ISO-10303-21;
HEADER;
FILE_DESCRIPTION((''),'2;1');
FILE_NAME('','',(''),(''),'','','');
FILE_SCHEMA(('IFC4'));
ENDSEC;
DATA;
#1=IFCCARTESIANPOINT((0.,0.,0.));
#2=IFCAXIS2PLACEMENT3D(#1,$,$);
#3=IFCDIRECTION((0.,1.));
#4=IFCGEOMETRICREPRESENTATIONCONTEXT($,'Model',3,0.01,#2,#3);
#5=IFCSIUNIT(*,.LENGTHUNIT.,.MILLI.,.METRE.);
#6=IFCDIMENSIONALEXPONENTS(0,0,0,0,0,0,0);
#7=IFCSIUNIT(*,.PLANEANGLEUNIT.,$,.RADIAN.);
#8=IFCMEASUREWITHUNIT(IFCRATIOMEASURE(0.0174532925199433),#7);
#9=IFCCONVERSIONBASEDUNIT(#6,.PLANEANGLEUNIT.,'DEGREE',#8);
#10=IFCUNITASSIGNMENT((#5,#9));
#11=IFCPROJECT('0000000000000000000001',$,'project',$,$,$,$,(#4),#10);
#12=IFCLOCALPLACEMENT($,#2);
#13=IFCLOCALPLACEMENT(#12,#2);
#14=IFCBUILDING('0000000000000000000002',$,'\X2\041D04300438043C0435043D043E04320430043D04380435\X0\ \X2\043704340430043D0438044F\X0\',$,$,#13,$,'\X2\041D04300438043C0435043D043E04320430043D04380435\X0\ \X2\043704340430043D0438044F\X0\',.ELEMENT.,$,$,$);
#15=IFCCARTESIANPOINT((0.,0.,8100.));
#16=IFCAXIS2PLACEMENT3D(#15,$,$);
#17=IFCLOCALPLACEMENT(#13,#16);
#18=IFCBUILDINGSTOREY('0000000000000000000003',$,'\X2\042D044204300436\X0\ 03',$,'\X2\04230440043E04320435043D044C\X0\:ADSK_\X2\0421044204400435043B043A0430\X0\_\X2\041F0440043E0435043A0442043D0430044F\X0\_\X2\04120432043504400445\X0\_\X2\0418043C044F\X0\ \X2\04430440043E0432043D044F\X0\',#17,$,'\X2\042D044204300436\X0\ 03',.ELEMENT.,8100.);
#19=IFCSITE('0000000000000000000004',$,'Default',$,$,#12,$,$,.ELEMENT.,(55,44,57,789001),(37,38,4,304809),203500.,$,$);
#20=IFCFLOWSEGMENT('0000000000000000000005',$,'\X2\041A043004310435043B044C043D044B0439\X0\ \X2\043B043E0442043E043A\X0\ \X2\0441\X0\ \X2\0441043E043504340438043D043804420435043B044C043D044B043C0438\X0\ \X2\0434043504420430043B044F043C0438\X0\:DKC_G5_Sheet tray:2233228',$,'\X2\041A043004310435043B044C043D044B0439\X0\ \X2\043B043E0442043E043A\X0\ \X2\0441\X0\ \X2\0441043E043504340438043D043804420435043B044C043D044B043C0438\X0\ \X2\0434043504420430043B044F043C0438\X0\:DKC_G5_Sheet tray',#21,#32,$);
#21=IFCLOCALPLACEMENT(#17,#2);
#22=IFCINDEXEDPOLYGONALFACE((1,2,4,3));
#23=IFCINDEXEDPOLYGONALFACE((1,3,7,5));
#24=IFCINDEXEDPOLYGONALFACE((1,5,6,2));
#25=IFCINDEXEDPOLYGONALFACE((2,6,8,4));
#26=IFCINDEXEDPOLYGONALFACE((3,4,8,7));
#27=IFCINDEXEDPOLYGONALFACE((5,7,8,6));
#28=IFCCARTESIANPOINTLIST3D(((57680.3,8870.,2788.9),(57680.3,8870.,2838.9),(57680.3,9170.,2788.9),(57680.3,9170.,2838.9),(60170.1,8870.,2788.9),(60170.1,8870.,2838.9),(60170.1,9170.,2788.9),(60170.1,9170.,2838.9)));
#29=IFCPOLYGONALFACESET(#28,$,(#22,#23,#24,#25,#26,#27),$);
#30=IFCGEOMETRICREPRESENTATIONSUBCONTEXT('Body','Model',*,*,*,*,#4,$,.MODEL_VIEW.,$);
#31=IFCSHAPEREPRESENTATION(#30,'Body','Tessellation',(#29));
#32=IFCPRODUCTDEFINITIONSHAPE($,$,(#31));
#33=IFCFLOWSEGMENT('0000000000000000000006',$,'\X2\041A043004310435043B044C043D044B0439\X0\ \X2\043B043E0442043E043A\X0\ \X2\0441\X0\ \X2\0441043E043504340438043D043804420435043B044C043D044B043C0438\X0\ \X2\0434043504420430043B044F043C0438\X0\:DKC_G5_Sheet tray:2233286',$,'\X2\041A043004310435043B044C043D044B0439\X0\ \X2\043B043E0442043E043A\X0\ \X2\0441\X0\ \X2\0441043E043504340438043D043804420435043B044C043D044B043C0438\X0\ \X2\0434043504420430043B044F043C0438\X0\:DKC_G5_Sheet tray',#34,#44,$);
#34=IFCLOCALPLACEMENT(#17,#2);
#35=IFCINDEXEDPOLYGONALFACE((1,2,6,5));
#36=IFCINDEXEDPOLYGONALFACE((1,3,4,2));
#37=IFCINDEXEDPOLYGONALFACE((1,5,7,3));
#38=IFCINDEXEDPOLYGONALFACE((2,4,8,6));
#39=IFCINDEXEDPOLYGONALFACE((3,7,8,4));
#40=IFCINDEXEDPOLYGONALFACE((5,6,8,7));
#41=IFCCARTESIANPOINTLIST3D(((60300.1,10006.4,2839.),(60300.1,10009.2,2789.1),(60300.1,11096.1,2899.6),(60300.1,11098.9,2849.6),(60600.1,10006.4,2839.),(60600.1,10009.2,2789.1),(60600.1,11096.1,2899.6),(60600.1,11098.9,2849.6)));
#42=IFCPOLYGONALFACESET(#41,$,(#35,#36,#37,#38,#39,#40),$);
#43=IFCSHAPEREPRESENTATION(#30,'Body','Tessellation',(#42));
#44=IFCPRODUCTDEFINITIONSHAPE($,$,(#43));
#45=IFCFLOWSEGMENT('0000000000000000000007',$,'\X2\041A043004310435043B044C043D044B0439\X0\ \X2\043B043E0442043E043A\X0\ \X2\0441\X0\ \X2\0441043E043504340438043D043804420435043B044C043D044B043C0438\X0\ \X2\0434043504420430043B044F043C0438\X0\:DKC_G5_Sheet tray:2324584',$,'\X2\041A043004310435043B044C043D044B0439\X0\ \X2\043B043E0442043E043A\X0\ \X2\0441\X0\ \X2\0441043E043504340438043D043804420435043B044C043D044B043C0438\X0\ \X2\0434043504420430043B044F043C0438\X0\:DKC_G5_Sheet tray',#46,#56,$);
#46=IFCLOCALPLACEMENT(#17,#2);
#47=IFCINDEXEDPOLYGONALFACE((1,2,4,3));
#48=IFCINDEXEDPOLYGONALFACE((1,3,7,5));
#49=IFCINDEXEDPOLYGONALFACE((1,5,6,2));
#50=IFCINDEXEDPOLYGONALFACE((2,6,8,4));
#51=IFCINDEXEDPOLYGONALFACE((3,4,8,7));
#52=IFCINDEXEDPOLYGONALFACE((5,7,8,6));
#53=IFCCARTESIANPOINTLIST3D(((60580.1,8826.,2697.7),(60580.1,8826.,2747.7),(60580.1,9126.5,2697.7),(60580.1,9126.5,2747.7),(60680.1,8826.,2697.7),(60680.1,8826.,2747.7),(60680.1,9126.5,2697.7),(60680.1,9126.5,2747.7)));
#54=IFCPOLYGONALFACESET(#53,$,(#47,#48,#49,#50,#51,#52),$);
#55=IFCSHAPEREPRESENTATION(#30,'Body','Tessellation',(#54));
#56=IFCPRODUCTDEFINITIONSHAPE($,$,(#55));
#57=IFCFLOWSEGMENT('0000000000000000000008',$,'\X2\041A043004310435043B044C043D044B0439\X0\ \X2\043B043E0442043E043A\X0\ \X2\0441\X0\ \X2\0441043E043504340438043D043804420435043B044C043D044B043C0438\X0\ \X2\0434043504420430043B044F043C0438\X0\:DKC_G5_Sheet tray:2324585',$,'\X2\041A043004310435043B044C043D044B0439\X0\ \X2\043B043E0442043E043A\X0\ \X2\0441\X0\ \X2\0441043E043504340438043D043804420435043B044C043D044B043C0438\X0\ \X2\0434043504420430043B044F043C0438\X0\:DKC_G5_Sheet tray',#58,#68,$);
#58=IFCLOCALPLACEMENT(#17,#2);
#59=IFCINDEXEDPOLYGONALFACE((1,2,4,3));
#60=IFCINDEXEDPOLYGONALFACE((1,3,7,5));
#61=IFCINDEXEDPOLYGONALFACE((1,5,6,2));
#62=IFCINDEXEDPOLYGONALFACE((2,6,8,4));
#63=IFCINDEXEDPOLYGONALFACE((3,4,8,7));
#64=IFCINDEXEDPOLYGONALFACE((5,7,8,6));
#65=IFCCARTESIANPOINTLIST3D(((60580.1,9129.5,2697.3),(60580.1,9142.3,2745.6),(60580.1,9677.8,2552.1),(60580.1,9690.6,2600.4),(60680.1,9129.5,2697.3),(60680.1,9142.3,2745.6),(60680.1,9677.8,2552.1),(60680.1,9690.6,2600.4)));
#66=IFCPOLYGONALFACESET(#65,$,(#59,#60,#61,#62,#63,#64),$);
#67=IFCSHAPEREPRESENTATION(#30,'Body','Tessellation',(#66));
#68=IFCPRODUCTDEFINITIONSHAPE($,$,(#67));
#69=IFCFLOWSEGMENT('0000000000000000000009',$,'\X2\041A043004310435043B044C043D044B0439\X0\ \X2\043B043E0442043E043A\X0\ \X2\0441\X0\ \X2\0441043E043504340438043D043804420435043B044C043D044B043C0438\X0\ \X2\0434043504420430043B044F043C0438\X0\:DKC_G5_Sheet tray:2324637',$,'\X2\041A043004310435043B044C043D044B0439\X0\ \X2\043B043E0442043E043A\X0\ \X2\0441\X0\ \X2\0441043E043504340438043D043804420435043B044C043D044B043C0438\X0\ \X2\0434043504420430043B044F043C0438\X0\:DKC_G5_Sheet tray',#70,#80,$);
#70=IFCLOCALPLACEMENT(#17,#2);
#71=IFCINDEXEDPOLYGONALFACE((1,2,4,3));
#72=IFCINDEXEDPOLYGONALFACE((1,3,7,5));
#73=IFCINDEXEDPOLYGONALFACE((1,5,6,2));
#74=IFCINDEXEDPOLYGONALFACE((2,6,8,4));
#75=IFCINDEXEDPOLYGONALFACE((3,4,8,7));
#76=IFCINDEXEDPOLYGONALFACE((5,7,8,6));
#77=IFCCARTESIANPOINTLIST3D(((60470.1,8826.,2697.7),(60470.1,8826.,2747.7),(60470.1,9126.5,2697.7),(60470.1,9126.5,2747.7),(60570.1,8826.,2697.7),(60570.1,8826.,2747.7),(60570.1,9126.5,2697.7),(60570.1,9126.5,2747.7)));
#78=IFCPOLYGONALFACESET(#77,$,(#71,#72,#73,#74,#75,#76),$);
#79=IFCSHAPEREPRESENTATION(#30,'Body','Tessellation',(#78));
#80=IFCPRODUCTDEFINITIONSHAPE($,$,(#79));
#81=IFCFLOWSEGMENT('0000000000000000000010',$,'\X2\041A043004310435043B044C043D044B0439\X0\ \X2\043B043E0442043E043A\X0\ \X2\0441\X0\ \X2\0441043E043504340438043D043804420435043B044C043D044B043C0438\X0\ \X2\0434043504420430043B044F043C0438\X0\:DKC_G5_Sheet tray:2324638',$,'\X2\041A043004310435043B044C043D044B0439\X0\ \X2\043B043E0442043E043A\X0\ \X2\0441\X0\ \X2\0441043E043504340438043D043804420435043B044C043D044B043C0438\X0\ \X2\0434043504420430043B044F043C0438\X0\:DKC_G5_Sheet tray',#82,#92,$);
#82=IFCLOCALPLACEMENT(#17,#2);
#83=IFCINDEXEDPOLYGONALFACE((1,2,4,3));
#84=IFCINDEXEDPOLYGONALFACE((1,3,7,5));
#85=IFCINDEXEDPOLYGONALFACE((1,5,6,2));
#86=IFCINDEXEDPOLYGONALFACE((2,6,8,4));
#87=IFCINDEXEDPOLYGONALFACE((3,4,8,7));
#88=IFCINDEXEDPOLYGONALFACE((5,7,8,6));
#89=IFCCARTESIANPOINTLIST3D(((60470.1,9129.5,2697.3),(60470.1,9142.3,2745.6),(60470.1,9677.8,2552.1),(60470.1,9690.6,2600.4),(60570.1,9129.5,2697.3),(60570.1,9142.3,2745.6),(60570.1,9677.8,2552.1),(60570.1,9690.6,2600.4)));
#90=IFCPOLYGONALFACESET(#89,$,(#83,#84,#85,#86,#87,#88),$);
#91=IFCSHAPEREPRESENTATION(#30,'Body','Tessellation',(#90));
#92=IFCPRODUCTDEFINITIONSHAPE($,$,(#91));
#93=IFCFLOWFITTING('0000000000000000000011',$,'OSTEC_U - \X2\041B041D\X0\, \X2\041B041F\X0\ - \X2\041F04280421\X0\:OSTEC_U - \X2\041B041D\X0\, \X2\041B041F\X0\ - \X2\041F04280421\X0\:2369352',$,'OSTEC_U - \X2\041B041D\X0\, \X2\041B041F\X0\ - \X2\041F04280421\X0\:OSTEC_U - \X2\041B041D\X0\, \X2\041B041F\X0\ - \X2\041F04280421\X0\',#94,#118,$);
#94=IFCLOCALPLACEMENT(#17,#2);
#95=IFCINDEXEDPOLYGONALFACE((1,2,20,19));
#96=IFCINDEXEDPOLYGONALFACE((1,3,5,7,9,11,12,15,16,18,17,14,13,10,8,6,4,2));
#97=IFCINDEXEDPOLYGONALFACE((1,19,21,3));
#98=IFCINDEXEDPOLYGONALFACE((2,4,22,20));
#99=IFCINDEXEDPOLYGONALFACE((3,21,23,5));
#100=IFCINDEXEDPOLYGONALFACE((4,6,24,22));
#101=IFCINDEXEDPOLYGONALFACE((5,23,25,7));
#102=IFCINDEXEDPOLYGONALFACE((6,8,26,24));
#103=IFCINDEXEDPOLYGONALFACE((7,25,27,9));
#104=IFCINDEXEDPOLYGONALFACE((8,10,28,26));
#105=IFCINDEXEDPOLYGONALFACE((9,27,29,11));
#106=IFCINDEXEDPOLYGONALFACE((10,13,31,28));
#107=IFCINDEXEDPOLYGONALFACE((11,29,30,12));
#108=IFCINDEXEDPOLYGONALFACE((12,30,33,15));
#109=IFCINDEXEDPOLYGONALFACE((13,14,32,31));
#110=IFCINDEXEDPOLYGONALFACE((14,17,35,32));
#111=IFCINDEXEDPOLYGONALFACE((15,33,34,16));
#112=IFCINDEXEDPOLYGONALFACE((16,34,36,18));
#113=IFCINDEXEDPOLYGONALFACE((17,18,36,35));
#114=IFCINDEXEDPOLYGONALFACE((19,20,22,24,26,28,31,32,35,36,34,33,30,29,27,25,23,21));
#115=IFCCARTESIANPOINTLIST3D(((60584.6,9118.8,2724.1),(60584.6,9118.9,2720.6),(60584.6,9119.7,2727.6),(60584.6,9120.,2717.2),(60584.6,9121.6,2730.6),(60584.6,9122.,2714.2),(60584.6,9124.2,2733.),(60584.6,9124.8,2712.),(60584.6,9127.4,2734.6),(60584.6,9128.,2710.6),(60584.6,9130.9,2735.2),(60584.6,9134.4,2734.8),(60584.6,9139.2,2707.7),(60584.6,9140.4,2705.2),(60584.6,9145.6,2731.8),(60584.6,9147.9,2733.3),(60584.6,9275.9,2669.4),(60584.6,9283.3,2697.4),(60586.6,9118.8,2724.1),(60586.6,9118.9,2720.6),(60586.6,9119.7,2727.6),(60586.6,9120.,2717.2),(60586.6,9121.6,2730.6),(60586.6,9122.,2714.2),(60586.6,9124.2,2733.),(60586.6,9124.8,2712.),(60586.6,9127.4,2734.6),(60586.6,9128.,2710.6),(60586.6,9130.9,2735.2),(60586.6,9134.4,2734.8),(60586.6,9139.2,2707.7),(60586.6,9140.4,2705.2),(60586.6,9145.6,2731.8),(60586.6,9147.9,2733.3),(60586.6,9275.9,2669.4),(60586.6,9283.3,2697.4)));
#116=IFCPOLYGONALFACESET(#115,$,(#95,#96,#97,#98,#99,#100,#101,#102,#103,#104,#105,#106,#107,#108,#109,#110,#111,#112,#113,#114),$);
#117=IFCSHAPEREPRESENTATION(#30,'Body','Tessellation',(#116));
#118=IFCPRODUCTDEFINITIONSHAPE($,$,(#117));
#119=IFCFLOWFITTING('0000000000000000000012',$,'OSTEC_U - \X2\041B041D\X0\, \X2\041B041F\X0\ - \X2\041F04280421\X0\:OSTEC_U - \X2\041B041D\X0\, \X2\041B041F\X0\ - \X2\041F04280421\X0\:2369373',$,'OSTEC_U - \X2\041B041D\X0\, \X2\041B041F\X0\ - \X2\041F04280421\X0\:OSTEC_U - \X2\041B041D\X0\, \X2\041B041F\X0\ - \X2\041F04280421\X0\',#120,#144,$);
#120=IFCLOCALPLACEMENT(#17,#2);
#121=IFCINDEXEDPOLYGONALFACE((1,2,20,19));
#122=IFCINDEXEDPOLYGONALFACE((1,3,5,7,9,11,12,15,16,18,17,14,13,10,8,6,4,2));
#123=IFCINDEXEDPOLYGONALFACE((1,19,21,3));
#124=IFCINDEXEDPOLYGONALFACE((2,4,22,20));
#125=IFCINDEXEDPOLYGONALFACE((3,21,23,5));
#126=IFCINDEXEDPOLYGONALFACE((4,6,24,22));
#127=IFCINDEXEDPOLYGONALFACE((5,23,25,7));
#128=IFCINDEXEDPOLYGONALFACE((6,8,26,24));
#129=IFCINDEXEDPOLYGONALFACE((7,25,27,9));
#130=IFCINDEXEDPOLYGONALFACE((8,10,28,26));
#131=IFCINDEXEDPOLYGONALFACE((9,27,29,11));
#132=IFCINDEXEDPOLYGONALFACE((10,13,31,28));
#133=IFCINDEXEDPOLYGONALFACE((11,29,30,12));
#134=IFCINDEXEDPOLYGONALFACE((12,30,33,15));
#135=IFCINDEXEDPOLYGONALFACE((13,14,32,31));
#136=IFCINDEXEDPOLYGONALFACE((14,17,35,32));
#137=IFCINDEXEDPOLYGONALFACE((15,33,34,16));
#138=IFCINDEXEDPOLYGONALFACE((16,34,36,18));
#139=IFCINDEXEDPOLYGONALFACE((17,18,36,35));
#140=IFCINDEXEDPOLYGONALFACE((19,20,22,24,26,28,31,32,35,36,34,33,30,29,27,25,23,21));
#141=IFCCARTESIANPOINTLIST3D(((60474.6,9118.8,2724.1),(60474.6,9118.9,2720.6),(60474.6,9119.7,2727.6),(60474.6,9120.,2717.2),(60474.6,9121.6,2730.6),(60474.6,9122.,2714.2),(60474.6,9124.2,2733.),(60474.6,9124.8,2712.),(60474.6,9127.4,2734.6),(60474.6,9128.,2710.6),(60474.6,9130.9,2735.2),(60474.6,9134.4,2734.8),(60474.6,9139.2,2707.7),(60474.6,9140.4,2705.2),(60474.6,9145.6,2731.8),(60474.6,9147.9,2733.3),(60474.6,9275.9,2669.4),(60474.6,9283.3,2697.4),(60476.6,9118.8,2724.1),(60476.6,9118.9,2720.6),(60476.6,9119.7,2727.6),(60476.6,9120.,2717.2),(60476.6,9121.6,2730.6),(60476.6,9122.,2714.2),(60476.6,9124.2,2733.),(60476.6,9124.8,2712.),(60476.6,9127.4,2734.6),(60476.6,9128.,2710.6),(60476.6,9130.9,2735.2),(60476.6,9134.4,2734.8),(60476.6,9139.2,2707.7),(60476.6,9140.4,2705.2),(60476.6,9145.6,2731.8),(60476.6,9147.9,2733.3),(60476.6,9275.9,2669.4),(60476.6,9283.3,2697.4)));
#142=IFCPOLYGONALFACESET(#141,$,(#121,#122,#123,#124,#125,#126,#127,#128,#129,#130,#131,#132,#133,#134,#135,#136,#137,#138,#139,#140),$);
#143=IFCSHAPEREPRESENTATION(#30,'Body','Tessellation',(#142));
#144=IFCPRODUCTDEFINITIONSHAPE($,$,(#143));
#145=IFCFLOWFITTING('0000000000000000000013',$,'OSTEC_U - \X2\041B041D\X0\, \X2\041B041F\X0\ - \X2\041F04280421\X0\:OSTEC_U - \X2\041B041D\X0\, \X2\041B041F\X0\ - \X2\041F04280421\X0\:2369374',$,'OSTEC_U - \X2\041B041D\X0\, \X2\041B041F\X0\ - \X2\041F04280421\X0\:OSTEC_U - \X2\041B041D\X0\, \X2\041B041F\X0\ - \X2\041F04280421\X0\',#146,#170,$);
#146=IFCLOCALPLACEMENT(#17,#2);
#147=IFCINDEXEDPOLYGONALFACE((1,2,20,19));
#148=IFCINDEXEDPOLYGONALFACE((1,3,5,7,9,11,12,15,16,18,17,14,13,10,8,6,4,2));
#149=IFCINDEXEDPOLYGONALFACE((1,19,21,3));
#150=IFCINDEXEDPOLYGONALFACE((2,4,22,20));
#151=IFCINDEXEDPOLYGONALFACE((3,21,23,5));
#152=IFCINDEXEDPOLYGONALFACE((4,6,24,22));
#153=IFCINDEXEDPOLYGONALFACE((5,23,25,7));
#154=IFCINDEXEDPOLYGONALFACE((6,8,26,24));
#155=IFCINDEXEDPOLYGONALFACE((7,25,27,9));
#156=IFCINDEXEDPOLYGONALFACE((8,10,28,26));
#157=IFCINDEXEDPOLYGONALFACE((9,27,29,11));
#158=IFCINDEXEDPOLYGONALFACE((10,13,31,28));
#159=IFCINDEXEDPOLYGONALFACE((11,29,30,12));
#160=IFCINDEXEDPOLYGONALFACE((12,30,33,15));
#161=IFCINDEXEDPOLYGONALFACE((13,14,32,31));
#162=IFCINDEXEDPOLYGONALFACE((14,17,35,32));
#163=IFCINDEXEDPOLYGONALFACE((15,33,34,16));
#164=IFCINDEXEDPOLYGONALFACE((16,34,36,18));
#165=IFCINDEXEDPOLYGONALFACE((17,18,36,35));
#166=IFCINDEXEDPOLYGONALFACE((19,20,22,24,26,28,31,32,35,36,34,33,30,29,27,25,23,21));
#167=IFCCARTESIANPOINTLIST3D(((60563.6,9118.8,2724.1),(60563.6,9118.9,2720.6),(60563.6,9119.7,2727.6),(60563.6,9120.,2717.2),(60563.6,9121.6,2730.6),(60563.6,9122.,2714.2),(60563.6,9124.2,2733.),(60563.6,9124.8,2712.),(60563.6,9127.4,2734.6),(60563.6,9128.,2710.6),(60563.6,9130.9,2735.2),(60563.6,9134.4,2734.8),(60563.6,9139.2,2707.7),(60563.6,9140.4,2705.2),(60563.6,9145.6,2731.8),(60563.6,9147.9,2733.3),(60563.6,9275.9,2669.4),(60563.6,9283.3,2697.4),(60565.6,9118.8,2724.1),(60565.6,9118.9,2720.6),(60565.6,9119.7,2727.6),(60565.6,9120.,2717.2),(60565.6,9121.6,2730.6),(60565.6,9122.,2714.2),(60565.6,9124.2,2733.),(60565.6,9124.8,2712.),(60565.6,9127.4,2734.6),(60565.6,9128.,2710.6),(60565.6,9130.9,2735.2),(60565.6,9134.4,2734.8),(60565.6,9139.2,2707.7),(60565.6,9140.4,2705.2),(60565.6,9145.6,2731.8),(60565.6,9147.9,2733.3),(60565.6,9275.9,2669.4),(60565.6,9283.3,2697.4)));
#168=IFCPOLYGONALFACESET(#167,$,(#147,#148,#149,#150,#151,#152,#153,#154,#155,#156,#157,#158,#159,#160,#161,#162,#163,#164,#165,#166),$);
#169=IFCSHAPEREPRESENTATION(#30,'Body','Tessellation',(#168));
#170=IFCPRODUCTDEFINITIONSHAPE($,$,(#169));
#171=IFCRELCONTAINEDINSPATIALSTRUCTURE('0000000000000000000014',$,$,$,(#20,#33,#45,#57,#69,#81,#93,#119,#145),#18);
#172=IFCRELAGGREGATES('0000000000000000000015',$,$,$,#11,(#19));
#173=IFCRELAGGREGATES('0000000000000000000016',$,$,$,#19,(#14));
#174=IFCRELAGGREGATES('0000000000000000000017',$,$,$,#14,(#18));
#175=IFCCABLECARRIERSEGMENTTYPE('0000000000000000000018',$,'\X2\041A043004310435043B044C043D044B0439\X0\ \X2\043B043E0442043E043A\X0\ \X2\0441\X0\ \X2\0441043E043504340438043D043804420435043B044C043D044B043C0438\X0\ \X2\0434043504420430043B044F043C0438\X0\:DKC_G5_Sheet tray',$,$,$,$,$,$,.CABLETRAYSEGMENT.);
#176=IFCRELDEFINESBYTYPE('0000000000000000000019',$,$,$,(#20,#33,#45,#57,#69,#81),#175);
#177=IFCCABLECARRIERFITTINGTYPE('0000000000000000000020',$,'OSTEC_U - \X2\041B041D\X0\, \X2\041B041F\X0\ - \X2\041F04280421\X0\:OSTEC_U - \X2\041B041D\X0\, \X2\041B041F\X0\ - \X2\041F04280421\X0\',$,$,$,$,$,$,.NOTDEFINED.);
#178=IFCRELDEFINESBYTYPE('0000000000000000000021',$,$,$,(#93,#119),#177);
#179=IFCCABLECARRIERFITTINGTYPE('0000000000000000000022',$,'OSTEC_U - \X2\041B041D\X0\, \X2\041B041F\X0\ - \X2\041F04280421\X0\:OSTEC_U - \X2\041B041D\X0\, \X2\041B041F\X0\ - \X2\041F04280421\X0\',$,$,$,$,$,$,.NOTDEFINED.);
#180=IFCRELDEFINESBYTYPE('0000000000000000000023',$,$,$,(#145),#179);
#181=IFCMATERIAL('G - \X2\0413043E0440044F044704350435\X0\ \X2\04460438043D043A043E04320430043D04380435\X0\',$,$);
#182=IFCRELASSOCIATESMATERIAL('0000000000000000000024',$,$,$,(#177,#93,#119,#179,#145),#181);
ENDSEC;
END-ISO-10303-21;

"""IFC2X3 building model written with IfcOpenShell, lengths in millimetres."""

from ifc_helpers import new_model, entity, si_unit, converted_unit, direction, frame, frame_2d, origin, place, context, subcontext, project, spatial, polyline, circle_curve, parameter, trimmed, segment, composite_curve, rectangle, outline, extrude, source, transform, mapped, material, type_object, type_shapes, element, save


model = new_model("IFC2X3")

# Units and contexts
model_context = context("Model", 3, precision=0.01, world=origin(), true_north=direction((0.0, 1.0)))
body_context = subcontext(model_context, "Body", "Model", "MODEL_VIEW")
ifc_project = project(units=[si_unit("LENGTHUNIT", "METRE", prefix="MILLI"), converted_unit("PLANEANGLEUNIT", "DEGREE", entity("IfcRatioMeasure", 0.0174532925199433), si_unit("PLANEANGLEUNIT", "RADIAN"), dimensions=[0, 0, 0, 0, 0, 0, 0])], contexts=[model_context])

# Site, building, storey
site_placement = place(None, frame((0.0, 0.0, 0.0)))
site = spatial("IfcSite", under=ifc_project, at=site_placement, Name="Default", CompositionType="ELEMENT", RefLatitude=(55, 44, 57, 789001), RefLongitude=(37, 38, 4, 304809), RefElevation=203500.0)
building_placement = place(site_placement, origin())
building = spatial("IfcBuilding", under=site, at=building_placement, Name="Наименование здания", LongName="Наименование здания", CompositionType="ELEMENT")
storey_placement = place(building_placement, frame((0.0, 0.0, 8100.0)))
storey = spatial("IfcBuildingStorey", under=building, at=storey_placement, Name="Этаж 03", ObjectType="Уровень:ADSK_Стрелка_Проектная_Вверх_Имя уровня", LongName="Этаж 03", CompositionType="ELEMENT", Elevation=8100.0)

# Flow segments
cable_carrier_segment_type = type_object("IfcCableCarrierSegmentType", Name="Кабельный лоток с соединительными деталями:DKC_G5_Sheet tray", PredefinedType="CABLETRAYSEGMENT")
flow_segment_1_placement = place(storey_placement, frame((57680.3, 8870.0, 2788.9)))
element("IfcFlowSegment", 1, at=flow_segment_1_placement, inside=storey, type_object=cable_carrier_segment_type, Name="Кабельный лоток с соединительными деталями:DKC_G5_Sheet tray:2233228", ObjectType="Кабельный лоток с соединительными деталями:DKC_G5_Sheet tray", context=body_context, shape_type="SweptSolid", body=[
    extrude(rectangle(XDim=2489.9, YDim=300.0, at=frame_2d((0.0, 0.0), x_axis=(1.0, 0.0))), frame((1244.9, 150.0, 0.0)), (0.0, 0.0, 1.0), 50.0),
])
flow_segment_2_placement = place(storey_placement, frame((60300.1, 10006.4, 2789.1)))
element("IfcFlowSegment", 2, at=flow_segment_2_placement, inside=storey, type_object=cable_carrier_segment_type, Name="Кабельный лоток с соединительными деталями:DKC_G5_Sheet tray:2233286", ObjectType="Кабельный лоток с соединительными деталями:DKC_G5_Sheet tray", context=body_context, shape_type="SweptSolid", body=[
    extrude(rectangle(XDim=50.0, YDim=1091.4, at=frame_2d((0.0, 0.0), x_axis=(0.0, 1.0))), frame((0.0, 546.2, 55.3), z_axis=(1.0, 0.0, 0.0), x_axis=(0.0, -0.998458, -0.055513)), (0.0, 0.0, 1.0), 300.0),
])
flow_segment_3_placement = place(storey_placement, frame((60580.1, 8826.0, 2697.7)))
element("IfcFlowSegment", 3, at=flow_segment_3_placement, inside=storey, type_object=cable_carrier_segment_type, Name="Кабельный лоток с соединительными деталями:DKC_G5_Sheet tray:2324584", ObjectType="Кабельный лоток с соединительными деталями:DKC_G5_Sheet tray", context=body_context, shape_type="SweptSolid", body=[
    extrude(rectangle(XDim=300.4, YDim=100.0, at=frame_2d((0.0, 0.0), x_axis=(1.0, 0.0))), frame((50.0, 150.2, 0.0), z_axis=(0.0, 0.0, 1.0), x_axis=(0.0, -1.0, 0.0)), (0.0, 0.0, 1.0), 50.0),
])
flow_segment_4_placement = place(storey_placement, frame((60580.1, 9129.5, 2552.1)))
element("IfcFlowSegment", 4, at=flow_segment_4_placement, inside=storey, type_object=cable_carrier_segment_type, Name="Кабельный лоток с соединительными деталями:DKC_G5_Sheet tray:2324585", ObjectType="Кабельный лоток с соединительными деталями:DKC_G5_Sheet tray", context=body_context, shape_type="SweptSolid", body=[
    extrude(rectangle(XDim=50.0, YDim=567.3, at=frame_2d((0.0, 0.0), x_axis=(0.0, 1.0))), frame((0.0, 280.6, 96.8), z_axis=(1.0, 0.0, 0.0), x_axis=(0.0, 0.966668, -0.256034)), (0.0, 0.0, 1.0), 100.0),
])
flow_segment_5_placement = place(storey_placement, frame((60470.1, 8826.0, 2697.7)))
element("IfcFlowSegment", 5, at=flow_segment_5_placement, inside=storey, type_object=cable_carrier_segment_type, Name="Кабельный лоток с соединительными деталями:DKC_G5_Sheet tray:2324637", ObjectType="Кабельный лоток с соединительными деталями:DKC_G5_Sheet tray", context=body_context, shape_type="SweptSolid", body=[
    extrude(rectangle(XDim=300.4, YDim=100.0, at=frame_2d((0.0, 0.0), x_axis=(1.0, 0.0))), frame((50.0, 150.2, 0.0), z_axis=(0.0, 0.0, 1.0), x_axis=(0.0, -1.0, 0.0)), (0.0, 0.0, 1.0), 50.0),
])
flow_segment_6_placement = place(storey_placement, frame((60470.1, 9129.5, 2552.1)))
element("IfcFlowSegment", 6, at=flow_segment_6_placement, inside=storey, type_object=cable_carrier_segment_type, Name="Кабельный лоток с соединительными деталями:DKC_G5_Sheet tray:2324638", ObjectType="Кабельный лоток с соединительными деталями:DKC_G5_Sheet tray", context=body_context, shape_type="SweptSolid", body=[
    extrude(rectangle(XDim=50.0, YDim=567.3, at=frame_2d((0.0, 0.0), x_axis=(0.0, 1.0))), frame((0.0, 280.6, 96.8), z_axis=(1.0, 0.0, 0.0), x_axis=(0.0, 0.966668, -0.256034)), (0.0, 0.0, 1.0), 100.0),
])

# Flow fittings
ifc_material = material(Name="G - Горячее цинкование")
cable_carrier_fitting_type_1 = type_object("IfcCableCarrierFittingType", Name="OSTEC_U - ЛН, ЛП - ПШС:OSTEC_U - ЛН, ЛП - ПШС", PredefinedType="NOTDEFINED", material=ifc_material)
shared_shape_1 = source(origin(), body_context, "Body", "SweptSolid", [
    extrude(outline(composite_curve([segment(trimmed(circle_curve(frame_2d((-44.6, 0.0), x_axis=(1.0, 0.0)), 12.5), [parameter(90.0)], [parameter(270.0)], True, "PARAMETER"), True, "CONTINUOUS"), segment(polyline([(-44.6, -12.5), (-33.1, -12.5)]), True, "CONTINUOUS"), segment(polyline([(-33.1, -12.5), (-31.2, -14.5)]), True, "CONTINUOUS"), segment(polyline([(-31.2, -14.5), (108.9, -14.5)]), True, "CONTINUOUS"), segment(polyline([(108.9, -14.5), (108.9, 14.5)]), True, "CONTINUOUS"), segment(polyline([(108.9, 14.5), (-31.2, 14.5)]), True, "CONTINUOUS"), segment(polyline([(-31.2, 14.5), (-33.1, 12.5)]), True, "CONTINUOUS"), segment(polyline([(-33.1, 12.5), (-44.6, 12.5)]), True, "CONTINUOUS")], self_intersect=False)), frame((44.6, 0.0, 0.0), z_axis=(0.0, 0.0, -1.0), x_axis=(1.0, 0.0, 0.0)), (0.0, 0.0, -1.0), 2.0),
])
type_shapes(cable_carrier_fitting_type_1, [shared_shape_1])
for number, where, z_axis, x_axis, name in (
    (7, (60586.6, 9131.2, 2722.7), (-1.0, 0.0, 0.0), (0.0, 0.966668, -0.256034), "OSTEC_U - ЛН, ЛП - ПШС:OSTEC_U - ЛН, ЛП - ПШС:2369352"),
    (8, (60476.6, 9131.2, 2722.7), (-1.0, 0.0, 0.0), (0.0, 0.966668, -0.256034), "OSTEC_U - ЛН, ЛП - ПШС:OSTEC_U - ЛН, ЛП - ПШС:2369373"),
):
    element("IfcFlowFitting", number, at=place(storey_placement, frame(where, z_axis=z_axis, x_axis=x_axis)), inside=storey, type_object=cable_carrier_fitting_type_1, material=ifc_material, Name=name, ObjectType="OSTEC_U - ЛН, ЛП - ПШС:OSTEC_U - ЛН, ЛП - ПШС", context=body_context, shape_type="MappedRepresentation", body=[
        mapped(shared_shape_1, transform((0.0, 0.0, 0.0), scale=1.0)),
    ])
cable_carrier_fitting_type_2 = type_object("IfcCableCarrierFittingType", Name="OSTEC_U - ЛН, ЛП - ПШС:OSTEC_U - ЛН, ЛП - ПШС", PredefinedType="NOTDEFINED", material=ifc_material)
shared_shape_2 = source(origin(), body_context, "Body", "SweptSolid", [
    extrude(outline(composite_curve([segment(trimmed(circle_curve(frame_2d((-44.6, 0.0), x_axis=(1.0, 0.0)), 12.5), [parameter(90.0)], [parameter(270.0)], True, "PARAMETER"), True, "CONTINUOUS"), segment(polyline([(-44.6, -12.5), (-33.1, -12.5)]), True, "CONTINUOUS"), segment(polyline([(-33.1, -12.5), (-31.2, -14.5)]), True, "CONTINUOUS"), segment(polyline([(-31.2, -14.5), (108.9, -14.5)]), True, "CONTINUOUS"), segment(polyline([(108.9, -14.5), (108.9, 14.5)]), True, "CONTINUOUS"), segment(polyline([(108.9, 14.5), (-31.2, 14.5)]), True, "CONTINUOUS"), segment(polyline([(-31.2, 14.5), (-33.1, 12.5)]), True, "CONTINUOUS"), segment(polyline([(-33.1, 12.5), (-44.6, 12.5)]), True, "CONTINUOUS")], self_intersect=False)), frame((44.6, 0.0, 0.0)), (0.0, 0.0, 1.0), 2.0),
])
type_shapes(cable_carrier_fitting_type_2, [shared_shape_2])
for number, where, z_axis, x_axis, name in (
    (9, (60563.6, 9131.2, 2722.7), (1.0, 0.0, 0.0), (0.0, 0.966668, -0.256034), "OSTEC_U - ЛН, ЛП - ПШС:OSTEC_U - ЛН, ЛП - ПШС:2369374"),
):
    element("IfcFlowFitting", number, at=place(storey_placement, frame(where, z_axis=z_axis, x_axis=x_axis)), inside=storey, type_object=cable_carrier_fitting_type_2, material=ifc_material, Name=name, ObjectType="OSTEC_U - ЛН, ЛП - ПШС:OSTEC_U - ЛН, ЛП - ПШС", context=body_context, shape_type="MappedRepresentation", body=[
        mapped(shared_shape_2, transform((0.0, 0.0, 0.0), scale=1.0)),
    ])

save(model, "model.ifc")
